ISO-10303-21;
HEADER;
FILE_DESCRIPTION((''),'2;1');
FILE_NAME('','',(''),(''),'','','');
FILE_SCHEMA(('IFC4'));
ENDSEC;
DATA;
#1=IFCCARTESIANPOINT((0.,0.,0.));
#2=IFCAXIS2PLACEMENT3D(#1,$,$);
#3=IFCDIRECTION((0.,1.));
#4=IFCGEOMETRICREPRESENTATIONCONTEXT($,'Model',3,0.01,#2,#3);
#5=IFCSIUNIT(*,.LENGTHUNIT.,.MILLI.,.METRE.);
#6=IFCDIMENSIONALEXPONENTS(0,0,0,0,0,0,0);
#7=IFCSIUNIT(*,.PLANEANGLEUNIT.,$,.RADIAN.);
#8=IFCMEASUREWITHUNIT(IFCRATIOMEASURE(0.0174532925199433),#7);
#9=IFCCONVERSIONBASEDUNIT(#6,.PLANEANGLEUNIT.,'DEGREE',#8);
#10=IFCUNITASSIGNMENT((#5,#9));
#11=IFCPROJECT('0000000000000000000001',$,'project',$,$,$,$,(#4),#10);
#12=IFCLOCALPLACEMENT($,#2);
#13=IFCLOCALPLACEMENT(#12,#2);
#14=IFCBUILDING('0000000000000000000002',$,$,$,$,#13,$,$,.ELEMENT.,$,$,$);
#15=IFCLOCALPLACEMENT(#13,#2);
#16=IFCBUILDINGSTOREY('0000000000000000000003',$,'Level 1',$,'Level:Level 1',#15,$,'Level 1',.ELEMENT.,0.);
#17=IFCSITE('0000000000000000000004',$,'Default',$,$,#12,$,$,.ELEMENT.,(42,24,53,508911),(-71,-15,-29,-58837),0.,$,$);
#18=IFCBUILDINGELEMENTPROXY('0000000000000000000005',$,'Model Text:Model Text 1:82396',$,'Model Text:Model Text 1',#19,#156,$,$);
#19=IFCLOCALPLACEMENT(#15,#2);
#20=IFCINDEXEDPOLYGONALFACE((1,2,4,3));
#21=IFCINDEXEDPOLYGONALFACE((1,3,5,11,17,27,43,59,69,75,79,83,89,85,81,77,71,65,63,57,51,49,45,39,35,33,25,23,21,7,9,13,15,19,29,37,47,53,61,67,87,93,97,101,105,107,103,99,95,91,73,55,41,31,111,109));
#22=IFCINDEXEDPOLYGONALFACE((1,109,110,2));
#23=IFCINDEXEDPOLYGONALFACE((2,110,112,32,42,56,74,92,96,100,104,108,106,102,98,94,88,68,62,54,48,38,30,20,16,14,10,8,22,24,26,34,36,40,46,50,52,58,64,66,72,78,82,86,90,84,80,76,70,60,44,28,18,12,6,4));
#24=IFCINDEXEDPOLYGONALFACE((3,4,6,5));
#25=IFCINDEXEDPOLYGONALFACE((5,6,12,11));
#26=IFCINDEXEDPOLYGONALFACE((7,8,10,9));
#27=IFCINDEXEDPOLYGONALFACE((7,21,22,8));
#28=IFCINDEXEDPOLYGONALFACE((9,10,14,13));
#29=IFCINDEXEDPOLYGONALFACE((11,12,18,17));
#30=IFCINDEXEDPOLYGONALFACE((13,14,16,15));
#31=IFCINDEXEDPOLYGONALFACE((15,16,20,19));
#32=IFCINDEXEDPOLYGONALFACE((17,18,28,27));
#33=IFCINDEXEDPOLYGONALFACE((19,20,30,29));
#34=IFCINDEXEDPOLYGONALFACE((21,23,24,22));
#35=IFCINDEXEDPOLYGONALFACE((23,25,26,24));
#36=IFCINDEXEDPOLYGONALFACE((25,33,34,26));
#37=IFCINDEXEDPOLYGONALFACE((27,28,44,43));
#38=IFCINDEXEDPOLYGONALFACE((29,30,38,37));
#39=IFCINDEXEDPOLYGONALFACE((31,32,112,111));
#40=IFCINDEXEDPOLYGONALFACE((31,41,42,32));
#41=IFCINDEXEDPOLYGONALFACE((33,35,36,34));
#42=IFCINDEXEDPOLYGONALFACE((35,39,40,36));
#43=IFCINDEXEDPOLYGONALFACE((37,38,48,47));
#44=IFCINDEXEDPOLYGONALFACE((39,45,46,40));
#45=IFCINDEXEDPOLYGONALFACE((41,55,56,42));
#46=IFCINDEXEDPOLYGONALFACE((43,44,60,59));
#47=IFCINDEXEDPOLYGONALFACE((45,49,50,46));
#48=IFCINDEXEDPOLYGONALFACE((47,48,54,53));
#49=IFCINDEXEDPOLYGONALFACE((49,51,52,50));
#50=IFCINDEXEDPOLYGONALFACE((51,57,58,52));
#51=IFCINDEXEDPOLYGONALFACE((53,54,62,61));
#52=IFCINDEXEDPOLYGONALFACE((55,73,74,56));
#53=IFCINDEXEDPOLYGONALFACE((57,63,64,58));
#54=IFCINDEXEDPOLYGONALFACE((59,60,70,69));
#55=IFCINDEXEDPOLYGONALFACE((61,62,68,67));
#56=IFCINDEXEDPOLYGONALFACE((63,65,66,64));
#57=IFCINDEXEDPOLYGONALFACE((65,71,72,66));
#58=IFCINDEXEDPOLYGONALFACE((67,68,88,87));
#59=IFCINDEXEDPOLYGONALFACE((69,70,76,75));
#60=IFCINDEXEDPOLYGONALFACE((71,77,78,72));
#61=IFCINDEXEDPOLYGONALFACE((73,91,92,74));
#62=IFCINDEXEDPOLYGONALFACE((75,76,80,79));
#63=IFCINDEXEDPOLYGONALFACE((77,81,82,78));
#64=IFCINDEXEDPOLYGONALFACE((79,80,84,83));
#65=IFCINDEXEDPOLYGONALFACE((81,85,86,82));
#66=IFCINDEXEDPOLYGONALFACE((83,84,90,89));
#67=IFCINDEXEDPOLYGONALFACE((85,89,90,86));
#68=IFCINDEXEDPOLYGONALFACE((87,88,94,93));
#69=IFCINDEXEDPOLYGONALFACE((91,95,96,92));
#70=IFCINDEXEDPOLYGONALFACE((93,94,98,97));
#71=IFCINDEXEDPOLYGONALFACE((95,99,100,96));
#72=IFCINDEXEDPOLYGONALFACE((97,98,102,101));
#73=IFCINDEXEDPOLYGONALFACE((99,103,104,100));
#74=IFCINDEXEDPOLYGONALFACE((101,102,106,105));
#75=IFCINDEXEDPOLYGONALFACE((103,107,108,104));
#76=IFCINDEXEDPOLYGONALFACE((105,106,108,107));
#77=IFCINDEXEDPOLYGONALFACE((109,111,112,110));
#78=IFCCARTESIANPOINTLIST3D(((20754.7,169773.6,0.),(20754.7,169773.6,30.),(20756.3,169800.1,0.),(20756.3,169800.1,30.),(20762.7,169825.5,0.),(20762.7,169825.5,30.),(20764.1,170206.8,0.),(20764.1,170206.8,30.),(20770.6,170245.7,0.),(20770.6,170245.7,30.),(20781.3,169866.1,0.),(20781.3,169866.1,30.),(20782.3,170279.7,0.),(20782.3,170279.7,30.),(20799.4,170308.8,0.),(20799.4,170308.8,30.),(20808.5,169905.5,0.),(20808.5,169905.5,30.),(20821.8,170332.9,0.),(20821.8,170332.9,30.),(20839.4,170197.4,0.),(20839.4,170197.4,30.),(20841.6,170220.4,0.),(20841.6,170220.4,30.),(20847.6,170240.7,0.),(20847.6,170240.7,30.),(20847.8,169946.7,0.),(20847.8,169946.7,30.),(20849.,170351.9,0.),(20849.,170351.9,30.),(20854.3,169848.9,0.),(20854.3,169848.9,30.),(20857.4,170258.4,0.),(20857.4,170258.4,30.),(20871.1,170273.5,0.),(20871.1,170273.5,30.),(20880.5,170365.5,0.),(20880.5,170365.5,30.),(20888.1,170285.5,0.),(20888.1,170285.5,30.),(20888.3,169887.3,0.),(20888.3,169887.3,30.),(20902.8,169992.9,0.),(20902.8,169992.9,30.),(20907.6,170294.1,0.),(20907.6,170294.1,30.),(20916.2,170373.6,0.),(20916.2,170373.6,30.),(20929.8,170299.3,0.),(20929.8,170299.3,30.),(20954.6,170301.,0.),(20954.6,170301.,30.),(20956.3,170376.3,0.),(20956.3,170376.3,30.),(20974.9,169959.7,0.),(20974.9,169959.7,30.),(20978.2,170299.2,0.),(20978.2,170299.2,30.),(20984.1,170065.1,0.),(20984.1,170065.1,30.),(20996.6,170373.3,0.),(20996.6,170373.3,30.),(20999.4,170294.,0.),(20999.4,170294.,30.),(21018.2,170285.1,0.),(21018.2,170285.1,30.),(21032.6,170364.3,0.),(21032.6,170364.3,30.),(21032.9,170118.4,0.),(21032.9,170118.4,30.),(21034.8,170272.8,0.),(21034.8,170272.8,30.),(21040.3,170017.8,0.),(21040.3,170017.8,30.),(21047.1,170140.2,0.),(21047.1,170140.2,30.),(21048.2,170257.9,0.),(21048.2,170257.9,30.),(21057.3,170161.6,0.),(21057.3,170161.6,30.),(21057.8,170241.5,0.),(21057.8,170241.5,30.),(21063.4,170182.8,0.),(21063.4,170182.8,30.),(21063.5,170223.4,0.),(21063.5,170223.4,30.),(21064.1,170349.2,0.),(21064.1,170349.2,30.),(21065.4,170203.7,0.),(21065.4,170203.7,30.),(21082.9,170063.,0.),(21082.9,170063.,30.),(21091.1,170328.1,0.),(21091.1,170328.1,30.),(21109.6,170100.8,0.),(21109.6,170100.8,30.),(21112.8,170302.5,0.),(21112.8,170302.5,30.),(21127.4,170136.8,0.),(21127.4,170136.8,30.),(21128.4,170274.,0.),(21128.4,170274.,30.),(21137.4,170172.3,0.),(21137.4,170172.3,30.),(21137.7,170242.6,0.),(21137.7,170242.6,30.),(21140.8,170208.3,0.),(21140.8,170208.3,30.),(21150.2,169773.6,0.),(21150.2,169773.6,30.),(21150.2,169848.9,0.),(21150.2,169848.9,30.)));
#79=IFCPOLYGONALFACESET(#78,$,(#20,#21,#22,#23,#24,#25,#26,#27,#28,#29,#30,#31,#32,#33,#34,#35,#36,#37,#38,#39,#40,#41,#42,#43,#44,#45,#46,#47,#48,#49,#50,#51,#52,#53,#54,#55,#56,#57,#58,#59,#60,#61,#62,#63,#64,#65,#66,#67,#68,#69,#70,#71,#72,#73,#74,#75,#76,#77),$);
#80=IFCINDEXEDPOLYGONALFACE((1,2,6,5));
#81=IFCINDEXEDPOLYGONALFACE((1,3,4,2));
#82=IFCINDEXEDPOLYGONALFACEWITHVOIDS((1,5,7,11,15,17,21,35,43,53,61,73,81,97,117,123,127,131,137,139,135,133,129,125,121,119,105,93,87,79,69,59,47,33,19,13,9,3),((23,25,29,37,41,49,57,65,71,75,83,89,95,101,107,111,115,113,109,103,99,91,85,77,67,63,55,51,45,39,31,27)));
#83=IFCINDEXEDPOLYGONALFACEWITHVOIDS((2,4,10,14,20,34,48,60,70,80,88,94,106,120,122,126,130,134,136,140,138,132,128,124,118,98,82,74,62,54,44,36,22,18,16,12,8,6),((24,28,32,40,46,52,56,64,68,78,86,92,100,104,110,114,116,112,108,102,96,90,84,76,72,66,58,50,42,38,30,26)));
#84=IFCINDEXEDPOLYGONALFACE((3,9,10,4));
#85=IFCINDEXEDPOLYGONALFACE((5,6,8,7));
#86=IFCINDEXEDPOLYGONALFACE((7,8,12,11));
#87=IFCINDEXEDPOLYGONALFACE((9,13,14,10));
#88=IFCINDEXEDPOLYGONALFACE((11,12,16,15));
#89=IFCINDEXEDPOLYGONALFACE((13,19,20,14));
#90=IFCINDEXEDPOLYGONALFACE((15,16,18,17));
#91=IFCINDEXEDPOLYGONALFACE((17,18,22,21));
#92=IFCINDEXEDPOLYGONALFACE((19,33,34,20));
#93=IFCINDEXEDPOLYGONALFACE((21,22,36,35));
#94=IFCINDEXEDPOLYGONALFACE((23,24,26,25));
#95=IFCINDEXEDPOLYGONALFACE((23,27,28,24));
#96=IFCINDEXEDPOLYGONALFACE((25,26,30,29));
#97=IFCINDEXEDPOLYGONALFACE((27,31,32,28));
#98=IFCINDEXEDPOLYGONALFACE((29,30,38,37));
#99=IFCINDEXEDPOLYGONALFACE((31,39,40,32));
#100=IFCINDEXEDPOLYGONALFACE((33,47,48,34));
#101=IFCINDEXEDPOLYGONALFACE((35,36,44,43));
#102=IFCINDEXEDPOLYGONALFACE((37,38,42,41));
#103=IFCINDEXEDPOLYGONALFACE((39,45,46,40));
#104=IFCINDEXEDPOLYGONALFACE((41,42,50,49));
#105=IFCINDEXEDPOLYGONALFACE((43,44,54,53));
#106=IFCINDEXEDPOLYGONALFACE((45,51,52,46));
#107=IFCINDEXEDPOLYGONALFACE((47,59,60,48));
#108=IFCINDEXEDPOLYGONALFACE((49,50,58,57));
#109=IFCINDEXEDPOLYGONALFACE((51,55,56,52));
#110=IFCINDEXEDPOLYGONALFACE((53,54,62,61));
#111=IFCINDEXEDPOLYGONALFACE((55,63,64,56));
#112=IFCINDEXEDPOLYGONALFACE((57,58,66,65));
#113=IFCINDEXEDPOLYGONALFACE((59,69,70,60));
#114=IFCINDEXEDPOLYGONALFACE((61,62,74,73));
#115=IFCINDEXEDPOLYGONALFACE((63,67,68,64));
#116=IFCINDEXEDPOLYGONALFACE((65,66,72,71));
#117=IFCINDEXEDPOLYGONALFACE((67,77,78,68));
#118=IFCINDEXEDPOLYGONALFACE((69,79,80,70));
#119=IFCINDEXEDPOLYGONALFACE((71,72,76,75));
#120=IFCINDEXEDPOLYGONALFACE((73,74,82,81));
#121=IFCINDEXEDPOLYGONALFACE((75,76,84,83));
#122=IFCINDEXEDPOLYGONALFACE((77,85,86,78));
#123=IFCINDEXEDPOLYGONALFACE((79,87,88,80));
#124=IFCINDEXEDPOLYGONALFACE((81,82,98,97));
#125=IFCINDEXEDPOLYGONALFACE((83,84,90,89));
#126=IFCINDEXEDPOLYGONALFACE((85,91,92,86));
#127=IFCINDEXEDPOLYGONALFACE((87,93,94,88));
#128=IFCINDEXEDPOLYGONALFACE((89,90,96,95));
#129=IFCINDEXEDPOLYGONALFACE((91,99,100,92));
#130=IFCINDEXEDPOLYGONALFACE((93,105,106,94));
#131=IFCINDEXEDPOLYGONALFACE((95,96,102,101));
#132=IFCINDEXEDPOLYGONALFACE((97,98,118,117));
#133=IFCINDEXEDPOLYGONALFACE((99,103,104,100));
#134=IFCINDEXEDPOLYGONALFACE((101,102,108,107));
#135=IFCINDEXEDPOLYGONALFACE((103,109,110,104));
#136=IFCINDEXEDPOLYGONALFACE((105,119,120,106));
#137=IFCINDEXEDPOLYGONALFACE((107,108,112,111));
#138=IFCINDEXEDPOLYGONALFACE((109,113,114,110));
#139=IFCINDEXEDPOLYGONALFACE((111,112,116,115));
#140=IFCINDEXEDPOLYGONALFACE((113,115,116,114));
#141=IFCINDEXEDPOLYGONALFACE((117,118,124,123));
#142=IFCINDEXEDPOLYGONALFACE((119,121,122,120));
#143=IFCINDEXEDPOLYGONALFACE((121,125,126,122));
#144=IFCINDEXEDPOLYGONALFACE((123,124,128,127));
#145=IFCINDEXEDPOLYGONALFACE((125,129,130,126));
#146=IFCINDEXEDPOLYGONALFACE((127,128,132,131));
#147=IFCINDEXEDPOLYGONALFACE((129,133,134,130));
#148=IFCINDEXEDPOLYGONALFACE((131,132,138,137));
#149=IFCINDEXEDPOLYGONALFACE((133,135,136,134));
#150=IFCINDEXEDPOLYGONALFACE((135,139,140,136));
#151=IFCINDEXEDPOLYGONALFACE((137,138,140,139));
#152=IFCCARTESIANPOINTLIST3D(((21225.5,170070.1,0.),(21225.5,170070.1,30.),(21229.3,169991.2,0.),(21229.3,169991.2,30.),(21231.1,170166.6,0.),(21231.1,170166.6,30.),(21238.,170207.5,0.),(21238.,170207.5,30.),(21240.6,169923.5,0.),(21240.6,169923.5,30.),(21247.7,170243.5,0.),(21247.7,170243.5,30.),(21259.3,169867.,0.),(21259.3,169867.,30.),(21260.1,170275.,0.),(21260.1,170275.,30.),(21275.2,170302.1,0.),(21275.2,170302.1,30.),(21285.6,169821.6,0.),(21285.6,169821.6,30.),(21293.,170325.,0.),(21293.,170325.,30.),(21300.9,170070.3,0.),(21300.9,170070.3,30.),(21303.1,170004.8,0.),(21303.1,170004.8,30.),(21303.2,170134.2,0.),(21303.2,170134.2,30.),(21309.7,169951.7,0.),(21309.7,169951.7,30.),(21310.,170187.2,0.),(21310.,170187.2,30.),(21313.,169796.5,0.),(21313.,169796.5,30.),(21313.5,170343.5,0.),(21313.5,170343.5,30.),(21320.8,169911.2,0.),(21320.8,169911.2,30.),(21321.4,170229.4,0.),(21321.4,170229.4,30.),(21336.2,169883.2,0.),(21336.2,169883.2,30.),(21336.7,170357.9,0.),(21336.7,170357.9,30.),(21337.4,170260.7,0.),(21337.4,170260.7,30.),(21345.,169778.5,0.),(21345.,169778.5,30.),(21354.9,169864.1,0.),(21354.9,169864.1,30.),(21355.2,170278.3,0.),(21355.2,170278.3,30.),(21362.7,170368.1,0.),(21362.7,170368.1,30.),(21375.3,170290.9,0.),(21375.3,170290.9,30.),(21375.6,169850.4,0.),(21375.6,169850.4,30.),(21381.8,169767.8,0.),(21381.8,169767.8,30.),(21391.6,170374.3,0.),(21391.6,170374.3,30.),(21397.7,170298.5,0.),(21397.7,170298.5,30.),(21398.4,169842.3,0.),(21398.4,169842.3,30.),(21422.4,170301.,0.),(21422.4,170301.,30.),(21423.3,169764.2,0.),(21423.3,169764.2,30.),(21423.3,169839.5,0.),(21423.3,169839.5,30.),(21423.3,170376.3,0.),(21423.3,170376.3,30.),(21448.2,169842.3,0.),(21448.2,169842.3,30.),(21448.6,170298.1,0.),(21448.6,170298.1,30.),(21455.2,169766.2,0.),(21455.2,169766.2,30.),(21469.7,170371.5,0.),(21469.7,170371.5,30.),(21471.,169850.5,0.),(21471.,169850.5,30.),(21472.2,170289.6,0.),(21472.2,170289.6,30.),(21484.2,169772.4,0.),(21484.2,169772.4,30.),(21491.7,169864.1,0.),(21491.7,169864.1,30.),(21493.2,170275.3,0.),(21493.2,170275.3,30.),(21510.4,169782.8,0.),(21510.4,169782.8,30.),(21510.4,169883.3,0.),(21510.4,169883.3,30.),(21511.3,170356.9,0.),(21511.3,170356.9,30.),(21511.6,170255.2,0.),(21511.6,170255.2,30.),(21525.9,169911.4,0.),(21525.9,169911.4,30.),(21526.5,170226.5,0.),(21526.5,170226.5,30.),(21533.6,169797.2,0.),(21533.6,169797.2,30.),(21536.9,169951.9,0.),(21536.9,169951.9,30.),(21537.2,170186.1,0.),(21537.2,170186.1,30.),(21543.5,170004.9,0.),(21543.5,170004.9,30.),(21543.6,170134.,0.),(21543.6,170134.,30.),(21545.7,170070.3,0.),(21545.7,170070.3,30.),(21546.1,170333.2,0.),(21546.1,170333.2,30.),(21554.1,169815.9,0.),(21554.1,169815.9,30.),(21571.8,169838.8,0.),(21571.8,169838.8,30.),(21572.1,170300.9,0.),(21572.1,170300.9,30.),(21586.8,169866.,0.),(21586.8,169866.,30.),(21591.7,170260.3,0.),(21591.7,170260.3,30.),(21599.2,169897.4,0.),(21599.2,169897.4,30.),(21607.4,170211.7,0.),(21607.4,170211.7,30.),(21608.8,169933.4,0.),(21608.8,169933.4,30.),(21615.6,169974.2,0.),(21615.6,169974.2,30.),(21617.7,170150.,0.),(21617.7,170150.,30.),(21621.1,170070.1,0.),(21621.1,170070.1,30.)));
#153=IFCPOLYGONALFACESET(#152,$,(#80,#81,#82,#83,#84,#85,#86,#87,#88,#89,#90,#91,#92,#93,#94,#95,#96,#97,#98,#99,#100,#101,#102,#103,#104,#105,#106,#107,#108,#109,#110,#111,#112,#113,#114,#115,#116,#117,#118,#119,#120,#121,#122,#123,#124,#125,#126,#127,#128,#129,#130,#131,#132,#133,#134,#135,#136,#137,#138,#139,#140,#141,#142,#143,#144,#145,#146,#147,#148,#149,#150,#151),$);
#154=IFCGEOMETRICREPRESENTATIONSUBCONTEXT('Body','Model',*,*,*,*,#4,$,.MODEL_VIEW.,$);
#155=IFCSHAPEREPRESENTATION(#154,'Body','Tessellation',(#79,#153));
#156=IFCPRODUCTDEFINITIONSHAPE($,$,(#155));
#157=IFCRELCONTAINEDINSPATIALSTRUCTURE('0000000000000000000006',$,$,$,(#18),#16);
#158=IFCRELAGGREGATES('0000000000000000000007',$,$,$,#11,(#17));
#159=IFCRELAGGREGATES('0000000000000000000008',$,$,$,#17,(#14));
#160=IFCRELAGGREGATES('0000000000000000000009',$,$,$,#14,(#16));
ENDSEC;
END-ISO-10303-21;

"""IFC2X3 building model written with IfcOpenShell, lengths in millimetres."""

from ifc_helpers import new_model, entity, si_unit, converted_unit, direction, frame, origin, place, context, subcontext, project, spatial, polyline, outline, extrude, element, save


model = new_model("IFC2X3")

# Units and contexts
model_context = context("Model", 3, precision=0.01, world=origin(), true_north=direction((0.0, 1.0)))
body_context = subcontext(model_context, "Body", "Model", "MODEL_VIEW")
ifc_project = project(units=[si_unit("LENGTHUNIT", "METRE", prefix="MILLI"), converted_unit("PLANEANGLEUNIT", "DEGREE", entity("IfcRatioMeasure", 0.0174532925199433), si_unit("PLANEANGLEUNIT", "RADIAN"), dimensions=[0, 0, 0, 0, 0, 0, 0])], contexts=[model_context])

# Site, building, storey
site_placement = place(None, origin())
site = spatial("IfcSite", under=ifc_project, at=site_placement, Name="Default", CompositionType="ELEMENT", RefLatitude=(42, 24, 53, 508911), RefLongitude=(-71, -15, -29, -58837), RefElevation=0.0)
building_placement = place(site_placement, origin())
building = spatial("IfcBuilding", under=site, at=building_placement, CompositionType="ELEMENT")
storey_placement = place(building_placement, origin())
storey = spatial("IfcBuildingStorey", under=building, at=storey_placement, Name="Level 1", ObjectType="Level:Level 1", LongName="Level 1", CompositionType="ELEMENT", Elevation=0.0)

# Building element proxy
proxy_1_placement = place(storey_placement, origin())
element("IfcBuildingElementProxy", 1, at=proxy_1_placement, inside=storey, Name="Model Text:Model Text 1:82396", ObjectType="Model Text:Model Text 1", context=body_context, shape_type="SweptSolid", body=[
    extrude(outline(polyline([(-190.2, -317.5), (-190.2, -392.8), (205.4, -392.8), (203.7, -366.3), (197.3, -340.9), (178.7, -300.3), (151.5, -260.9), (112.2, -219.7), (57.2, -173.6), (-24.1, -101.3), (-72.9, -48.0), (-87.1, -26.3), (-97.3, -4.8), (-103.4, 16.4), (-105.4, 37.3), (-103.5, 57.0), (-97.7, 75.0), (-88.2, 91.5), (-74.7, 106.4), (-58.2, 118.7), (-39.4, 127.5), (-18.2, 132.8), (5.4, 134.6), (30.2, 132.9), (52.4, 127.7), (72.0, 119.1), (88.9, 107.1), (102.6, 92.0), (112.5, 74.3), (118.5, 54.0), (120.6, 31.0), (196.0, 40.4), (189.5, 79.3), (177.7, 113.3), (160.6, 142.4), (138.2, 166.5), (111.0, 185.5), (79.5, 199.1), (43.8, 207.2), (3.8, 209.9), (-36.6, 206.9), (-72.5, 197.9), (-104.0, 182.8), (-131.1, 161.7), (-152.8, 136.1), (-168.3, 107.6), (-177.6, 76.2), (-180.8, 41.9), (-177.4, 5.8), (-167.4, -29.6), (-149.5, -65.6), (-122.8, -103.4), (-80.3, -148.6), (-14.9, -206.7), (71.8, -279.1), (105.8, -317.5), (-190.2, -317.5)])), frame((20960.0, 170166.4, 0.0), z_axis=(0.0, 0.0, -1.0), x_axis=(-1.0, 0.0, 0.0)), (0.0, 0.0, -1.0), 30.0),
    extrude(outline(polyline([(-10.6, -198.7), (68.3, -198.7), (136.5, -190.7), (193.9, -174.7), (240.5, -150.6), (266.9, -124.4), (286.3, -93.2), (298.8, -57.0), (304.3, -15.7), (303.8, 16.2), (299.0, 45.5), (289.9, 72.1), (276.6, 96.0), (258.9, 117.3), (236.9, 136.2), (210.4, 152.5), (179.6, 166.3), (144.1, 177.6), (103.7, 186.3), (8.2, 196.4), (-71.8, 196.7), (-134.0, 189.4), (-183.3, 176.1), (-224.7, 158.4), (-258.2, 133.9), (-283.5, 100.3), (-300.1, 59.5), (-307.1, 13.4), (-306.6, -18.4), (-301.8, -47.5), (-292.8, -74.0), (-279.6, -97.9), (-262.0, -119.2), (-240.0, -138.1), (-213.6, -154.5), (-182.8, -168.4), (-147.3, -179.8), (-106.7, -188.6), (-10.6, -198.7)]), holes=[polyline([(-7.2, -123.5), (-71.0, -118.2), (-123.6, -108.8), (-165.2, -95.4), (-195.7, -78.0), (-212.4, -59.4), (-224.1, -38.7), (-230.6, -15.9), (-231.9, 8.9), (-227.8, 35.0), (-218.1, 58.1), (-202.8, 78.4), (-182.0, 95.8), (-152.6, 109.4), (-111.7, 118.1), (-59.4, 122.0), (4.4, 121.1), (69.6, 115.8), (122.2, 106.7), (162.2, 93.7), (189.5, 77.0), (207.7, 57.4), (220.4, 36.0), (227.5, 12.8), (229.1, -12.1), (225.2, -36.8), (215.9, -59.2), (201.3, -79.3), (181.4, -97.1), (152.6, -111.2), (111.6, -120.3), (58.3, -124.4), (-7.2, -123.5)])]), frame((21424.6, 170068.9, 0.0), z_axis=(0.0, 0.0, 1.0), x_axis=(0.047515, -0.998871, 0.0)), (0.0, 0.0, 1.0), 30.0),
])

save(model, "model.ifc")
